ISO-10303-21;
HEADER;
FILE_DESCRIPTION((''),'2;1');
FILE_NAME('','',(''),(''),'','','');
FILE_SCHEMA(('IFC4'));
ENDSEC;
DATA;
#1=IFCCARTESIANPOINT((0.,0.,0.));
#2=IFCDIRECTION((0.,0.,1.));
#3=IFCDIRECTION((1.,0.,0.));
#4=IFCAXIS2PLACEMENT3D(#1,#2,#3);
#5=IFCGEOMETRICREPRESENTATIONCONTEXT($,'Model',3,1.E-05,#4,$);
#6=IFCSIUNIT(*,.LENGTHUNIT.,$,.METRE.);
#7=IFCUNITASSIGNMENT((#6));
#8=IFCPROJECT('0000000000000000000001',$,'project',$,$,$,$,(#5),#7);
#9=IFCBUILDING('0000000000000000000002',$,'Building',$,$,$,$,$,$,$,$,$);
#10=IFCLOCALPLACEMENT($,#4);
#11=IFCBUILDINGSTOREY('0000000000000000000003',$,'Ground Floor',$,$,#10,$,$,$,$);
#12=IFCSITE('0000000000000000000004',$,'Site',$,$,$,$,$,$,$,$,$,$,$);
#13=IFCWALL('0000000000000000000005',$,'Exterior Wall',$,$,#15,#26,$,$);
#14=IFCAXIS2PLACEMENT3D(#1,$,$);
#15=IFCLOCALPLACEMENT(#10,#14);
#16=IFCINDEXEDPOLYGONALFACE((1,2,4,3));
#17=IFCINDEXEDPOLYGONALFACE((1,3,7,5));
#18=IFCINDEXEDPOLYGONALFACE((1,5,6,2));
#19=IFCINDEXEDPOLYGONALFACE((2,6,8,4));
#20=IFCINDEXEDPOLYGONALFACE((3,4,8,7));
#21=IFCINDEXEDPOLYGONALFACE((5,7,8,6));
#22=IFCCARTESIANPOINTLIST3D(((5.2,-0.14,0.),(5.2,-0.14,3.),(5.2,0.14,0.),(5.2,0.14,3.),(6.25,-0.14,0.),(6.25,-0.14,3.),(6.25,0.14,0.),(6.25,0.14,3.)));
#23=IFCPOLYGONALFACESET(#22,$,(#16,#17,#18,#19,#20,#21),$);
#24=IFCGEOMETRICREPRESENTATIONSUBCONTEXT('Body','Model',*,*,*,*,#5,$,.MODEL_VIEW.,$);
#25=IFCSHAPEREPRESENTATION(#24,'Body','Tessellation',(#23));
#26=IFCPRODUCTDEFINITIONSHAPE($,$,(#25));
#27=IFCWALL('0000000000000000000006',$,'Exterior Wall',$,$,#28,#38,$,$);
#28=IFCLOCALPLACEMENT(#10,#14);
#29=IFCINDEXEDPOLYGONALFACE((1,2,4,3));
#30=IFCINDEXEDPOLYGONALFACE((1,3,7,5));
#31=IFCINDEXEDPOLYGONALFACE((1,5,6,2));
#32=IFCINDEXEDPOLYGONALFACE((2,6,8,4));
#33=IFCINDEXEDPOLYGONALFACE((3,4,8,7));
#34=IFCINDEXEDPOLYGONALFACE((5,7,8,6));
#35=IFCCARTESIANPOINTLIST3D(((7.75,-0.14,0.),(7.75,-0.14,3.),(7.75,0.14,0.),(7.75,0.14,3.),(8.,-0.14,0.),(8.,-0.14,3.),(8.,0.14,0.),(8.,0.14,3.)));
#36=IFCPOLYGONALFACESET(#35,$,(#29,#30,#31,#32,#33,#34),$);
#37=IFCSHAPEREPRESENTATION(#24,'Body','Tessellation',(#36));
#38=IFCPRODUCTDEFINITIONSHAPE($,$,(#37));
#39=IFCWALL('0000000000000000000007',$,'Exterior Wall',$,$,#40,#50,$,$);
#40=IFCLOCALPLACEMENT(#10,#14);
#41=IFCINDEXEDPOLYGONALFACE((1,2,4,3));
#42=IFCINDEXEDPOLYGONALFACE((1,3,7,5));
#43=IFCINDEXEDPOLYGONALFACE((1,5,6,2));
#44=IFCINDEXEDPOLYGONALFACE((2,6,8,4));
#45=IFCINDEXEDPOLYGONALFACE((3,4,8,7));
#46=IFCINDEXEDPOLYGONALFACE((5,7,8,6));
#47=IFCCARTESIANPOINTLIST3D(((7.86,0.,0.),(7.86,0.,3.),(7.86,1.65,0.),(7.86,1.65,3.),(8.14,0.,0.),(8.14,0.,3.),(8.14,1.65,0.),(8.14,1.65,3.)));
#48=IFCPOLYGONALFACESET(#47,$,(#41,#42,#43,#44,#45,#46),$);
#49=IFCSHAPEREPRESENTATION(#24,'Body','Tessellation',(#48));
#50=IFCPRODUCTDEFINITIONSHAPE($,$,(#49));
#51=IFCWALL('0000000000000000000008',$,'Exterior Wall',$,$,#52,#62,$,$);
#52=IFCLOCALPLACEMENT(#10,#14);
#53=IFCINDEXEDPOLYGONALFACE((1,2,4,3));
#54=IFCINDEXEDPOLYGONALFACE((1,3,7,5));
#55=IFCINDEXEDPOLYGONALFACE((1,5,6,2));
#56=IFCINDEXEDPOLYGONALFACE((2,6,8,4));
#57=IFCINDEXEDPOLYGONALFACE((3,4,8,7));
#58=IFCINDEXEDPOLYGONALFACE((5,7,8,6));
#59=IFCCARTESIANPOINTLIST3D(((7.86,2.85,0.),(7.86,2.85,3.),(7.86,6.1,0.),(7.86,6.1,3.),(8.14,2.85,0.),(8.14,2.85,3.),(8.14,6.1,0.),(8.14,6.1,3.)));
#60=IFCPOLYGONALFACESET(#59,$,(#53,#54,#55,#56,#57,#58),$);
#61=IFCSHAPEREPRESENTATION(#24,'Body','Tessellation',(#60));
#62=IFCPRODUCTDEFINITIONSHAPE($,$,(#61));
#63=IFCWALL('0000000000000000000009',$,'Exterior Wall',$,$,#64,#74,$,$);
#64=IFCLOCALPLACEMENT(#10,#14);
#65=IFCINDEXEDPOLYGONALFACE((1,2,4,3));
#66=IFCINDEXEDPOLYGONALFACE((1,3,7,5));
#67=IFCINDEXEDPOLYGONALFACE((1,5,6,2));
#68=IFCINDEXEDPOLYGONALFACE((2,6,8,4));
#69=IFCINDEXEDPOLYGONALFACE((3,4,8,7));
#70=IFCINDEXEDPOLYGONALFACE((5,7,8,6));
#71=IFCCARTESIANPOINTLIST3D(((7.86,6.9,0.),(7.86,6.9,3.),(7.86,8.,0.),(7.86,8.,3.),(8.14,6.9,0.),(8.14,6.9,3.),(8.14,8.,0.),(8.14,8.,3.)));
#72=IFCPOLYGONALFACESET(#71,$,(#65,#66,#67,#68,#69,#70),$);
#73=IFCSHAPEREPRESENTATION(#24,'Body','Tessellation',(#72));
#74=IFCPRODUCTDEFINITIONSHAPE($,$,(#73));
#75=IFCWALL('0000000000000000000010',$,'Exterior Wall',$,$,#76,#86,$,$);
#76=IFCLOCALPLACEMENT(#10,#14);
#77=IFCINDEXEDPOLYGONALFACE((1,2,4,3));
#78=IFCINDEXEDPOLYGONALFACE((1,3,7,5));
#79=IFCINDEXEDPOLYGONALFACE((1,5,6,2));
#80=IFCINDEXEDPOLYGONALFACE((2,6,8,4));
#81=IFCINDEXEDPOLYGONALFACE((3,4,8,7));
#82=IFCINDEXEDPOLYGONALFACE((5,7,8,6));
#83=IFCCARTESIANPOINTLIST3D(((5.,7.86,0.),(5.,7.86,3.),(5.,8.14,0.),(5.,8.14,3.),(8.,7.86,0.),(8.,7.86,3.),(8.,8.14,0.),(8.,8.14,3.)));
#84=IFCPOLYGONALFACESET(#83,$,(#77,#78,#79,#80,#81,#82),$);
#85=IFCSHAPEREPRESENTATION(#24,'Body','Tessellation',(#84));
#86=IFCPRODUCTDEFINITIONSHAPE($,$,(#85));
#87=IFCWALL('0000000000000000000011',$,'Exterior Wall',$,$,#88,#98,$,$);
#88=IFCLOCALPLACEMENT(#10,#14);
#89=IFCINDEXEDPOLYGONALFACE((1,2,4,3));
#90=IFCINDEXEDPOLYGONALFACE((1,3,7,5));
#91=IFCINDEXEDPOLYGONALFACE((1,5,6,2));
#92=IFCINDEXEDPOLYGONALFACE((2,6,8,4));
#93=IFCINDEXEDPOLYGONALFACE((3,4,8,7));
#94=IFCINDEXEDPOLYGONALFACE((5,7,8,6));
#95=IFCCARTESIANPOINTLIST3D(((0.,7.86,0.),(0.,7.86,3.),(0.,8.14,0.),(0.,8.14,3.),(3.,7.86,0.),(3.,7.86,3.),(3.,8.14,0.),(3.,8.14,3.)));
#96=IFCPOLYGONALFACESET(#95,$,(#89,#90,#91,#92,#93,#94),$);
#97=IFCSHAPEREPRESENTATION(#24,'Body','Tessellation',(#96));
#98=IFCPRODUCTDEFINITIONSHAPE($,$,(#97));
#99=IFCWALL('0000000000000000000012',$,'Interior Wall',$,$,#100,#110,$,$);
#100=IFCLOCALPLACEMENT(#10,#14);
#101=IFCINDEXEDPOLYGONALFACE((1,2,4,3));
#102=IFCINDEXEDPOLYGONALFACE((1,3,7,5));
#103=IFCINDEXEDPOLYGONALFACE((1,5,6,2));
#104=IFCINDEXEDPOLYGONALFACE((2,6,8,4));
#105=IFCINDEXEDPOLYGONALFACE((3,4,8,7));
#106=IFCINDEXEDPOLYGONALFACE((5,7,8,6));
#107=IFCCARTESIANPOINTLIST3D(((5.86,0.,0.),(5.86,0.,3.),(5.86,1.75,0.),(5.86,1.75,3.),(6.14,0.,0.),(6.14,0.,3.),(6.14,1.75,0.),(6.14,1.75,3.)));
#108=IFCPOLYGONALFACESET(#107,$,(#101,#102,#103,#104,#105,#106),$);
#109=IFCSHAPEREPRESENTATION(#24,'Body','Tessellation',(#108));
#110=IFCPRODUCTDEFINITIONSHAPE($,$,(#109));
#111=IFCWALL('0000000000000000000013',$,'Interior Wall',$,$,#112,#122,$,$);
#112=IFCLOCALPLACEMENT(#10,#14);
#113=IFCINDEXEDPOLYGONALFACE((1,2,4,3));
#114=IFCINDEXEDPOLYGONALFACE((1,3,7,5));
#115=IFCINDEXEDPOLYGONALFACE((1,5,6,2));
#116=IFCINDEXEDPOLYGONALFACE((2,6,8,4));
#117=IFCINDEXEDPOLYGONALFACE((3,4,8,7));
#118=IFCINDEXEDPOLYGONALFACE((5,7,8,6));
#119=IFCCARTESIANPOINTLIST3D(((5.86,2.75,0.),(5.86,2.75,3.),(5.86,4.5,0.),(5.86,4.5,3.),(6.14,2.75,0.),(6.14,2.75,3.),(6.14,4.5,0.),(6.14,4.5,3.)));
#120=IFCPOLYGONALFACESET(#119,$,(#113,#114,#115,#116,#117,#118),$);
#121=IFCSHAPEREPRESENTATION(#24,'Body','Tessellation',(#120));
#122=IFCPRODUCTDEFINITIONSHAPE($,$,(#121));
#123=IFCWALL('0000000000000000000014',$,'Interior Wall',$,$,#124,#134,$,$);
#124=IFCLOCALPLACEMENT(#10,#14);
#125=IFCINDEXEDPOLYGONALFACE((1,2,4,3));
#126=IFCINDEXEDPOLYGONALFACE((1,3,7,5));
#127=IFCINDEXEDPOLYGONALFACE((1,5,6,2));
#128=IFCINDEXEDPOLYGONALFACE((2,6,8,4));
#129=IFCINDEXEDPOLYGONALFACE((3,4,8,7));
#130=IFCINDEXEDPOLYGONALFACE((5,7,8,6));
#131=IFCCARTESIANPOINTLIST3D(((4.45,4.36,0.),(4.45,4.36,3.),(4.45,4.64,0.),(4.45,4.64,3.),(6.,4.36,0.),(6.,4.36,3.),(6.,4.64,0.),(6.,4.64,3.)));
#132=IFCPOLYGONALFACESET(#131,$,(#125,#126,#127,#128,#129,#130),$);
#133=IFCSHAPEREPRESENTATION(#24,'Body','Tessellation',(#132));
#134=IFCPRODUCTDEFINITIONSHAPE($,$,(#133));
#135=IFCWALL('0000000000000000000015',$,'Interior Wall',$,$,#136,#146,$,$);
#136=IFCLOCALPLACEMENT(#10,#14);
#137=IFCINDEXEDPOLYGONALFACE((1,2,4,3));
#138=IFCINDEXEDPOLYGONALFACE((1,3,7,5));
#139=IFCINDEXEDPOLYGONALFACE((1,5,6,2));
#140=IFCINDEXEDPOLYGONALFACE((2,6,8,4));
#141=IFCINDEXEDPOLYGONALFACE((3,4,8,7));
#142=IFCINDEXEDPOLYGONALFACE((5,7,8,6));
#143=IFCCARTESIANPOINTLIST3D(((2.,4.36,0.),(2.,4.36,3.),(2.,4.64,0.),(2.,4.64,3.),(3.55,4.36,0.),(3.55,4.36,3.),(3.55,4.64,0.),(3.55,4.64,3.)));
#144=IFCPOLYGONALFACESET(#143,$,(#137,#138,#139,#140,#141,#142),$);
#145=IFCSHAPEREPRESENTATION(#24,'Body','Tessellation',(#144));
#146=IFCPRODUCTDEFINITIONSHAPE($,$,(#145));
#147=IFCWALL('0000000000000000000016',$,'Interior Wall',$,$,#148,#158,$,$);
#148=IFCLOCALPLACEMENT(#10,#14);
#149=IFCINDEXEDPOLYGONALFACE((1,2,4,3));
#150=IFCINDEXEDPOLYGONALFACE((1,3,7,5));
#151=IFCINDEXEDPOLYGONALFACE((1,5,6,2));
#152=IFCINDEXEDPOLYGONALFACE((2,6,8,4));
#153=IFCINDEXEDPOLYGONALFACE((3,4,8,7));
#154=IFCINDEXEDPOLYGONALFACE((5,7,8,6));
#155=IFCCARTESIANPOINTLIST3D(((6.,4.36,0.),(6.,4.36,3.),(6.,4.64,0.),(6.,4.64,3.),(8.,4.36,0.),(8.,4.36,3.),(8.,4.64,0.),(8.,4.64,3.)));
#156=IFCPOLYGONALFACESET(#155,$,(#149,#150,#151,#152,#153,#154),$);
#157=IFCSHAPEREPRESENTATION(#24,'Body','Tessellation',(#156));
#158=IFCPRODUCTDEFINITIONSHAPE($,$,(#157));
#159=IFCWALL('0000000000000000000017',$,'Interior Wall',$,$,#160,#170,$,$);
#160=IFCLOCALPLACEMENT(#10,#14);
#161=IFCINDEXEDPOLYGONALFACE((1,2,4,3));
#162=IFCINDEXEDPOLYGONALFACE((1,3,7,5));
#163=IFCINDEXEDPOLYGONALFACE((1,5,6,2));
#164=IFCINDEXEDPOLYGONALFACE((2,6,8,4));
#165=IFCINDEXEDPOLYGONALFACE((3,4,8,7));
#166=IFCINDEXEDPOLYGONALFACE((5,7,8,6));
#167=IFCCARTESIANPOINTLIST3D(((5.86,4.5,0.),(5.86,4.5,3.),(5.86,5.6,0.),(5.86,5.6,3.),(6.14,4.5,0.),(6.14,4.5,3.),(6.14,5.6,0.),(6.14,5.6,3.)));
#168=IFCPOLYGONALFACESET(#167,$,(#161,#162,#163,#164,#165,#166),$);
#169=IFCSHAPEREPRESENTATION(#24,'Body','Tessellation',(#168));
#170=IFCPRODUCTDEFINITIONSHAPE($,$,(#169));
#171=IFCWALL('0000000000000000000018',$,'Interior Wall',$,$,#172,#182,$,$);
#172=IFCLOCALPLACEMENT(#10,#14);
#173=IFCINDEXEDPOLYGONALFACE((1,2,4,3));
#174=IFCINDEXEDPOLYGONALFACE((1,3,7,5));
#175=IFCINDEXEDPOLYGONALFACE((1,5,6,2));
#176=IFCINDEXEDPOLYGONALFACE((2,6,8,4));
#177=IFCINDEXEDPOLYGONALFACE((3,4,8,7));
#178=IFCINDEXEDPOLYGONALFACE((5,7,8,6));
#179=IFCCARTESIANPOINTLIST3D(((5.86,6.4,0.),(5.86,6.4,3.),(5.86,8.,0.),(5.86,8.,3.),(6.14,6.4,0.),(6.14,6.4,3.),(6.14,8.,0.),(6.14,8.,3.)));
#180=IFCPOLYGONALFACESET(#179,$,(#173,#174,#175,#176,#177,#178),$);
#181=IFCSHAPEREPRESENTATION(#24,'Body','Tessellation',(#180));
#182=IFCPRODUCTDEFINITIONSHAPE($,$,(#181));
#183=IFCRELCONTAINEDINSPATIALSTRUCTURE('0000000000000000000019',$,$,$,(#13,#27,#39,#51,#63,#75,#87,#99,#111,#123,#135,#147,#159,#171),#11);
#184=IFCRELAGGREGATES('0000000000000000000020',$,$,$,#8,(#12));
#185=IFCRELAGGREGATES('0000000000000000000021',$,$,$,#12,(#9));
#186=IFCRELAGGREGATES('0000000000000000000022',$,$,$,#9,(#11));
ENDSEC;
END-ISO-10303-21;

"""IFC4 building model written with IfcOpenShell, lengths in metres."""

from ifc_helpers import new_model, si_unit, frame, origin_with_axes, place, context, subcontext, project, spatial, indexed_curve, outline, extrude, element, save


model = new_model("IFC4")

# Units and contexts
model_context = context("Model", 3, precision=1e-05, world=origin_with_axes())
body_context = subcontext(model_context, "Body", "Model", "MODEL_VIEW")
ifc_project = project(units=[si_unit("LENGTHUNIT", "METRE")], contexts=[model_context])

# Site, building, storey
site = spatial("IfcSite", under=ifc_project, Name="Site")
building = spatial("IfcBuilding", under=site, Name="Building")
storey_placement = place(None, origin_with_axes())
storey = spatial("IfcBuildingStorey", under=building, at=storey_placement, Name="Ground Floor")

# Walls
wall_1_placement = place(storey_placement, frame((5.2, 0.0, 0.0), z_axis=(0.0, 0.0, 1.0), x_axis=(1.0, 0.0, 0.0)))
element("IfcWall", 1, at=wall_1_placement, inside=storey, Name="Exterior Wall", context=body_context, shape_type="SweptSolid", body=[
    extrude(outline(indexed_curve([(0.0, 0.0), (0.0, 0.28), (1.05, 0.28), (1.05, 0.0), (0.0, 0.0)], self_intersect=False)), frame((0.0, -0.14, 0.0), z_axis=(0.0, 0.0, 1.0), x_axis=(1.0, 0.0, 0.0)), (0.0, 0.0, 1.0), 3.0),
])
wall_2_placement = place(storey_placement, frame((7.75, 0.0, 0.0), z_axis=(0.0, 0.0, 1.0), x_axis=(1.0, 0.0, 0.0)))
element("IfcWall", 2, at=wall_2_placement, inside=storey, Name="Exterior Wall", context=body_context, shape_type="SweptSolid", body=[
    extrude(outline(indexed_curve([(0.0, 0.0), (0.0, 0.28), (0.25, 0.28), (0.25, 0.0), (0.0, 0.0)], self_intersect=False)), frame((0.0, -0.14, 0.0), z_axis=(0.0, 0.0, 1.0), x_axis=(1.0, 0.0, 0.0)), (0.0, 0.0, 1.0), 3.0),
])
wall_3_placement = place(storey_placement, frame((8.0, 0.0, 0.0), z_axis=(0.0, 0.0, 1.0), x_axis=(0.0, 1.0, 0.0)))
element("IfcWall", 3, at=wall_3_placement, inside=storey, Name="Exterior Wall", context=body_context, shape_type="SweptSolid", body=[
    extrude(outline(indexed_curve([(0.0, 0.0), (0.0, 0.28), (1.65, 0.28), (1.65, 0.0), (0.0, 0.0)], self_intersect=False)), frame((0.0, -0.14, 0.0), z_axis=(0.0, 0.0, 1.0), x_axis=(1.0, 0.0, 0.0)), (0.0, 0.0, 1.0), 3.0),
])
wall_4_placement = place(storey_placement, frame((8.0, 2.85, 0.0), z_axis=(0.0, 0.0, 1.0), x_axis=(0.0, 1.0, 0.0)))
element("IfcWall", 4, at=wall_4_placement, inside=storey, Name="Exterior Wall", context=body_context, shape_type="SweptSolid", body=[
    extrude(outline(indexed_curve([(0.0, 0.0), (0.0, 0.28), (3.25, 0.28), (3.25, 0.0), (0.0, 0.0)], self_intersect=False)), frame((0.0, -0.14, 0.0), z_axis=(0.0, 0.0, 1.0), x_axis=(1.0, 0.0, 0.0)), (0.0, 0.0, 1.0), 3.0),
])
wall_5_placement = place(storey_placement, frame((8.0, 6.9, 0.0), z_axis=(0.0, 0.0, 1.0), x_axis=(0.0, 1.0, 0.0)))
element("IfcWall", 5, at=wall_5_placement, inside=storey, Name="Exterior Wall", context=body_context, shape_type="SweptSolid", body=[
    extrude(outline(indexed_curve([(0.0, 0.0), (0.0, 0.28), (1.1, 0.28), (1.1, 0.0), (0.0, 0.0)], self_intersect=False)), frame((0.0, -0.14, 0.0), z_axis=(0.0, 0.0, 1.0), x_axis=(1.0, 0.0, 0.0)), (0.0, 0.0, 1.0), 3.0),
])
for number, where, z_axis, x_axis, name in (
    (6, (8.0, 8.0, 0.0), (0.0, 0.0, 1.0), (-1.0, 0.0, 0.0), "Exterior Wall"),
    (7, (3.0, 8.0, 0.0), (0.0, 0.0, 1.0), (-1.0, 0.0, 0.0), "Exterior Wall"),
):
    element("IfcWall", number, at=place(storey_placement, frame(where, z_axis=z_axis, x_axis=x_axis)), inside=storey, Name=name, context=body_context, shape_type="SweptSolid", body=[
        extrude(outline(indexed_curve([(0.0, 0.0), (0.0, 0.28), (3.0, 0.28), (3.0, 0.0), (0.0, 0.0)], self_intersect=False)), frame((0.0, -0.14, 0.0), z_axis=(0.0, 0.0, 1.0), x_axis=(1.0, 0.0, 0.0)), (0.0, 0.0, 1.0), 3.0),
    ])
for number, where, z_axis, x_axis, name in (
    (8, (6.0, 0.0, 0.0), (0.0, 0.0, 1.0), (0.0, 1.0, 0.0), "Interior Wall"),
    (9, (6.0, 2.75, 0.0), (0.0, 0.0, 1.0), (0.0, 1.0, 0.0), "Interior Wall"),
):
    element("IfcWall", number, at=place(storey_placement, frame(where, z_axis=z_axis, x_axis=x_axis)), inside=storey, Name=name, context=body_context, shape_type="SweptSolid", body=[
        extrude(outline(indexed_curve([(0.0, 0.0), (0.0, 0.28), (1.75, 0.28), (1.75, 0.0), (0.0, 0.0)], self_intersect=False)), frame((0.0, -0.14, 0.0), z_axis=(0.0, 0.0, 1.0), x_axis=(1.0, 0.0, 0.0)), (0.0, 0.0, 1.0), 3.0),
    ])
for number, where, z_axis, x_axis, name in (
    (10, (6.0, 4.5, 0.0), (0.0, 0.0, 1.0), (-1.0, 0.0, 0.0), "Interior Wall"),
    (11, (3.55, 4.5, 0.0), (0.0, 0.0, 1.0), (-1.0, 0.0, 0.0), "Interior Wall"),
):
    element("IfcWall", number, at=place(storey_placement, frame(where, z_axis=z_axis, x_axis=x_axis)), inside=storey, Name=name, context=body_context, shape_type="SweptSolid", body=[
        extrude(outline(indexed_curve([(0.0, 0.0), (0.0, 0.28), (1.55, 0.28), (1.55, 0.0), (0.0, 0.0)], self_intersect=False)), frame((0.0, -0.14, 0.0), z_axis=(0.0, 0.0, 1.0), x_axis=(1.0, 0.0, 0.0)), (0.0, 0.0, 1.0), 3.0),
    ])
wall_6_placement = place(storey_placement, frame((8.0, 4.5, 0.0), z_axis=(0.0, 0.0, 1.0), x_axis=(-1.0, 0.0, 0.0)))
element("IfcWall", 12, at=wall_6_placement, inside=storey, Name="Interior Wall", context=body_context, shape_type="SweptSolid", body=[
    extrude(outline(indexed_curve([(0.0, 0.0), (0.0, 0.28), (2.0, 0.28), (2.0, 0.0), (0.0, 0.0)], self_intersect=False)), frame((0.0, -0.14, 0.0), z_axis=(0.0, 0.0, 1.0), x_axis=(1.0, 0.0, 0.0)), (0.0, 0.0, 1.0), 3.0),
])
wall_7_placement = place(storey_placement, frame((6.0, 4.5, 0.0), z_axis=(0.0, 0.0, 1.0), x_axis=(0.0, 1.0, 0.0)))
element("IfcWall", 13, at=wall_7_placement, inside=storey, Name="Interior Wall", context=body_context, shape_type="SweptSolid", body=[
    extrude(outline(indexed_curve([(0.0, 0.0), (0.0, 0.28), (1.1, 0.28), (1.1, 0.0), (0.0, 0.0)], self_intersect=False)), frame((0.0, -0.14, 0.0), z_axis=(0.0, 0.0, 1.0), x_axis=(1.0, 0.0, 0.0)), (0.0, 0.0, 1.0), 3.0),
])
wall_8_placement = place(storey_placement, frame((6.0, 6.4, 0.0), z_axis=(0.0, 0.0, 1.0), x_axis=(0.0, 1.0, 0.0)))
element("IfcWall", 14, at=wall_8_placement, inside=storey, Name="Interior Wall", context=body_context, shape_type="SweptSolid", body=[
    extrude(outline(indexed_curve([(0.0, 0.0), (0.0, 0.28), (1.6, 0.28), (1.6, 0.0), (0.0, 0.0)], self_intersect=False)), frame((0.0, -0.14, 0.0), z_axis=(0.0, 0.0, 1.0), x_axis=(1.0, 0.0, 0.0)), (0.0, 0.0, 1.0), 3.0),
])

save(model, "model.ifc")
